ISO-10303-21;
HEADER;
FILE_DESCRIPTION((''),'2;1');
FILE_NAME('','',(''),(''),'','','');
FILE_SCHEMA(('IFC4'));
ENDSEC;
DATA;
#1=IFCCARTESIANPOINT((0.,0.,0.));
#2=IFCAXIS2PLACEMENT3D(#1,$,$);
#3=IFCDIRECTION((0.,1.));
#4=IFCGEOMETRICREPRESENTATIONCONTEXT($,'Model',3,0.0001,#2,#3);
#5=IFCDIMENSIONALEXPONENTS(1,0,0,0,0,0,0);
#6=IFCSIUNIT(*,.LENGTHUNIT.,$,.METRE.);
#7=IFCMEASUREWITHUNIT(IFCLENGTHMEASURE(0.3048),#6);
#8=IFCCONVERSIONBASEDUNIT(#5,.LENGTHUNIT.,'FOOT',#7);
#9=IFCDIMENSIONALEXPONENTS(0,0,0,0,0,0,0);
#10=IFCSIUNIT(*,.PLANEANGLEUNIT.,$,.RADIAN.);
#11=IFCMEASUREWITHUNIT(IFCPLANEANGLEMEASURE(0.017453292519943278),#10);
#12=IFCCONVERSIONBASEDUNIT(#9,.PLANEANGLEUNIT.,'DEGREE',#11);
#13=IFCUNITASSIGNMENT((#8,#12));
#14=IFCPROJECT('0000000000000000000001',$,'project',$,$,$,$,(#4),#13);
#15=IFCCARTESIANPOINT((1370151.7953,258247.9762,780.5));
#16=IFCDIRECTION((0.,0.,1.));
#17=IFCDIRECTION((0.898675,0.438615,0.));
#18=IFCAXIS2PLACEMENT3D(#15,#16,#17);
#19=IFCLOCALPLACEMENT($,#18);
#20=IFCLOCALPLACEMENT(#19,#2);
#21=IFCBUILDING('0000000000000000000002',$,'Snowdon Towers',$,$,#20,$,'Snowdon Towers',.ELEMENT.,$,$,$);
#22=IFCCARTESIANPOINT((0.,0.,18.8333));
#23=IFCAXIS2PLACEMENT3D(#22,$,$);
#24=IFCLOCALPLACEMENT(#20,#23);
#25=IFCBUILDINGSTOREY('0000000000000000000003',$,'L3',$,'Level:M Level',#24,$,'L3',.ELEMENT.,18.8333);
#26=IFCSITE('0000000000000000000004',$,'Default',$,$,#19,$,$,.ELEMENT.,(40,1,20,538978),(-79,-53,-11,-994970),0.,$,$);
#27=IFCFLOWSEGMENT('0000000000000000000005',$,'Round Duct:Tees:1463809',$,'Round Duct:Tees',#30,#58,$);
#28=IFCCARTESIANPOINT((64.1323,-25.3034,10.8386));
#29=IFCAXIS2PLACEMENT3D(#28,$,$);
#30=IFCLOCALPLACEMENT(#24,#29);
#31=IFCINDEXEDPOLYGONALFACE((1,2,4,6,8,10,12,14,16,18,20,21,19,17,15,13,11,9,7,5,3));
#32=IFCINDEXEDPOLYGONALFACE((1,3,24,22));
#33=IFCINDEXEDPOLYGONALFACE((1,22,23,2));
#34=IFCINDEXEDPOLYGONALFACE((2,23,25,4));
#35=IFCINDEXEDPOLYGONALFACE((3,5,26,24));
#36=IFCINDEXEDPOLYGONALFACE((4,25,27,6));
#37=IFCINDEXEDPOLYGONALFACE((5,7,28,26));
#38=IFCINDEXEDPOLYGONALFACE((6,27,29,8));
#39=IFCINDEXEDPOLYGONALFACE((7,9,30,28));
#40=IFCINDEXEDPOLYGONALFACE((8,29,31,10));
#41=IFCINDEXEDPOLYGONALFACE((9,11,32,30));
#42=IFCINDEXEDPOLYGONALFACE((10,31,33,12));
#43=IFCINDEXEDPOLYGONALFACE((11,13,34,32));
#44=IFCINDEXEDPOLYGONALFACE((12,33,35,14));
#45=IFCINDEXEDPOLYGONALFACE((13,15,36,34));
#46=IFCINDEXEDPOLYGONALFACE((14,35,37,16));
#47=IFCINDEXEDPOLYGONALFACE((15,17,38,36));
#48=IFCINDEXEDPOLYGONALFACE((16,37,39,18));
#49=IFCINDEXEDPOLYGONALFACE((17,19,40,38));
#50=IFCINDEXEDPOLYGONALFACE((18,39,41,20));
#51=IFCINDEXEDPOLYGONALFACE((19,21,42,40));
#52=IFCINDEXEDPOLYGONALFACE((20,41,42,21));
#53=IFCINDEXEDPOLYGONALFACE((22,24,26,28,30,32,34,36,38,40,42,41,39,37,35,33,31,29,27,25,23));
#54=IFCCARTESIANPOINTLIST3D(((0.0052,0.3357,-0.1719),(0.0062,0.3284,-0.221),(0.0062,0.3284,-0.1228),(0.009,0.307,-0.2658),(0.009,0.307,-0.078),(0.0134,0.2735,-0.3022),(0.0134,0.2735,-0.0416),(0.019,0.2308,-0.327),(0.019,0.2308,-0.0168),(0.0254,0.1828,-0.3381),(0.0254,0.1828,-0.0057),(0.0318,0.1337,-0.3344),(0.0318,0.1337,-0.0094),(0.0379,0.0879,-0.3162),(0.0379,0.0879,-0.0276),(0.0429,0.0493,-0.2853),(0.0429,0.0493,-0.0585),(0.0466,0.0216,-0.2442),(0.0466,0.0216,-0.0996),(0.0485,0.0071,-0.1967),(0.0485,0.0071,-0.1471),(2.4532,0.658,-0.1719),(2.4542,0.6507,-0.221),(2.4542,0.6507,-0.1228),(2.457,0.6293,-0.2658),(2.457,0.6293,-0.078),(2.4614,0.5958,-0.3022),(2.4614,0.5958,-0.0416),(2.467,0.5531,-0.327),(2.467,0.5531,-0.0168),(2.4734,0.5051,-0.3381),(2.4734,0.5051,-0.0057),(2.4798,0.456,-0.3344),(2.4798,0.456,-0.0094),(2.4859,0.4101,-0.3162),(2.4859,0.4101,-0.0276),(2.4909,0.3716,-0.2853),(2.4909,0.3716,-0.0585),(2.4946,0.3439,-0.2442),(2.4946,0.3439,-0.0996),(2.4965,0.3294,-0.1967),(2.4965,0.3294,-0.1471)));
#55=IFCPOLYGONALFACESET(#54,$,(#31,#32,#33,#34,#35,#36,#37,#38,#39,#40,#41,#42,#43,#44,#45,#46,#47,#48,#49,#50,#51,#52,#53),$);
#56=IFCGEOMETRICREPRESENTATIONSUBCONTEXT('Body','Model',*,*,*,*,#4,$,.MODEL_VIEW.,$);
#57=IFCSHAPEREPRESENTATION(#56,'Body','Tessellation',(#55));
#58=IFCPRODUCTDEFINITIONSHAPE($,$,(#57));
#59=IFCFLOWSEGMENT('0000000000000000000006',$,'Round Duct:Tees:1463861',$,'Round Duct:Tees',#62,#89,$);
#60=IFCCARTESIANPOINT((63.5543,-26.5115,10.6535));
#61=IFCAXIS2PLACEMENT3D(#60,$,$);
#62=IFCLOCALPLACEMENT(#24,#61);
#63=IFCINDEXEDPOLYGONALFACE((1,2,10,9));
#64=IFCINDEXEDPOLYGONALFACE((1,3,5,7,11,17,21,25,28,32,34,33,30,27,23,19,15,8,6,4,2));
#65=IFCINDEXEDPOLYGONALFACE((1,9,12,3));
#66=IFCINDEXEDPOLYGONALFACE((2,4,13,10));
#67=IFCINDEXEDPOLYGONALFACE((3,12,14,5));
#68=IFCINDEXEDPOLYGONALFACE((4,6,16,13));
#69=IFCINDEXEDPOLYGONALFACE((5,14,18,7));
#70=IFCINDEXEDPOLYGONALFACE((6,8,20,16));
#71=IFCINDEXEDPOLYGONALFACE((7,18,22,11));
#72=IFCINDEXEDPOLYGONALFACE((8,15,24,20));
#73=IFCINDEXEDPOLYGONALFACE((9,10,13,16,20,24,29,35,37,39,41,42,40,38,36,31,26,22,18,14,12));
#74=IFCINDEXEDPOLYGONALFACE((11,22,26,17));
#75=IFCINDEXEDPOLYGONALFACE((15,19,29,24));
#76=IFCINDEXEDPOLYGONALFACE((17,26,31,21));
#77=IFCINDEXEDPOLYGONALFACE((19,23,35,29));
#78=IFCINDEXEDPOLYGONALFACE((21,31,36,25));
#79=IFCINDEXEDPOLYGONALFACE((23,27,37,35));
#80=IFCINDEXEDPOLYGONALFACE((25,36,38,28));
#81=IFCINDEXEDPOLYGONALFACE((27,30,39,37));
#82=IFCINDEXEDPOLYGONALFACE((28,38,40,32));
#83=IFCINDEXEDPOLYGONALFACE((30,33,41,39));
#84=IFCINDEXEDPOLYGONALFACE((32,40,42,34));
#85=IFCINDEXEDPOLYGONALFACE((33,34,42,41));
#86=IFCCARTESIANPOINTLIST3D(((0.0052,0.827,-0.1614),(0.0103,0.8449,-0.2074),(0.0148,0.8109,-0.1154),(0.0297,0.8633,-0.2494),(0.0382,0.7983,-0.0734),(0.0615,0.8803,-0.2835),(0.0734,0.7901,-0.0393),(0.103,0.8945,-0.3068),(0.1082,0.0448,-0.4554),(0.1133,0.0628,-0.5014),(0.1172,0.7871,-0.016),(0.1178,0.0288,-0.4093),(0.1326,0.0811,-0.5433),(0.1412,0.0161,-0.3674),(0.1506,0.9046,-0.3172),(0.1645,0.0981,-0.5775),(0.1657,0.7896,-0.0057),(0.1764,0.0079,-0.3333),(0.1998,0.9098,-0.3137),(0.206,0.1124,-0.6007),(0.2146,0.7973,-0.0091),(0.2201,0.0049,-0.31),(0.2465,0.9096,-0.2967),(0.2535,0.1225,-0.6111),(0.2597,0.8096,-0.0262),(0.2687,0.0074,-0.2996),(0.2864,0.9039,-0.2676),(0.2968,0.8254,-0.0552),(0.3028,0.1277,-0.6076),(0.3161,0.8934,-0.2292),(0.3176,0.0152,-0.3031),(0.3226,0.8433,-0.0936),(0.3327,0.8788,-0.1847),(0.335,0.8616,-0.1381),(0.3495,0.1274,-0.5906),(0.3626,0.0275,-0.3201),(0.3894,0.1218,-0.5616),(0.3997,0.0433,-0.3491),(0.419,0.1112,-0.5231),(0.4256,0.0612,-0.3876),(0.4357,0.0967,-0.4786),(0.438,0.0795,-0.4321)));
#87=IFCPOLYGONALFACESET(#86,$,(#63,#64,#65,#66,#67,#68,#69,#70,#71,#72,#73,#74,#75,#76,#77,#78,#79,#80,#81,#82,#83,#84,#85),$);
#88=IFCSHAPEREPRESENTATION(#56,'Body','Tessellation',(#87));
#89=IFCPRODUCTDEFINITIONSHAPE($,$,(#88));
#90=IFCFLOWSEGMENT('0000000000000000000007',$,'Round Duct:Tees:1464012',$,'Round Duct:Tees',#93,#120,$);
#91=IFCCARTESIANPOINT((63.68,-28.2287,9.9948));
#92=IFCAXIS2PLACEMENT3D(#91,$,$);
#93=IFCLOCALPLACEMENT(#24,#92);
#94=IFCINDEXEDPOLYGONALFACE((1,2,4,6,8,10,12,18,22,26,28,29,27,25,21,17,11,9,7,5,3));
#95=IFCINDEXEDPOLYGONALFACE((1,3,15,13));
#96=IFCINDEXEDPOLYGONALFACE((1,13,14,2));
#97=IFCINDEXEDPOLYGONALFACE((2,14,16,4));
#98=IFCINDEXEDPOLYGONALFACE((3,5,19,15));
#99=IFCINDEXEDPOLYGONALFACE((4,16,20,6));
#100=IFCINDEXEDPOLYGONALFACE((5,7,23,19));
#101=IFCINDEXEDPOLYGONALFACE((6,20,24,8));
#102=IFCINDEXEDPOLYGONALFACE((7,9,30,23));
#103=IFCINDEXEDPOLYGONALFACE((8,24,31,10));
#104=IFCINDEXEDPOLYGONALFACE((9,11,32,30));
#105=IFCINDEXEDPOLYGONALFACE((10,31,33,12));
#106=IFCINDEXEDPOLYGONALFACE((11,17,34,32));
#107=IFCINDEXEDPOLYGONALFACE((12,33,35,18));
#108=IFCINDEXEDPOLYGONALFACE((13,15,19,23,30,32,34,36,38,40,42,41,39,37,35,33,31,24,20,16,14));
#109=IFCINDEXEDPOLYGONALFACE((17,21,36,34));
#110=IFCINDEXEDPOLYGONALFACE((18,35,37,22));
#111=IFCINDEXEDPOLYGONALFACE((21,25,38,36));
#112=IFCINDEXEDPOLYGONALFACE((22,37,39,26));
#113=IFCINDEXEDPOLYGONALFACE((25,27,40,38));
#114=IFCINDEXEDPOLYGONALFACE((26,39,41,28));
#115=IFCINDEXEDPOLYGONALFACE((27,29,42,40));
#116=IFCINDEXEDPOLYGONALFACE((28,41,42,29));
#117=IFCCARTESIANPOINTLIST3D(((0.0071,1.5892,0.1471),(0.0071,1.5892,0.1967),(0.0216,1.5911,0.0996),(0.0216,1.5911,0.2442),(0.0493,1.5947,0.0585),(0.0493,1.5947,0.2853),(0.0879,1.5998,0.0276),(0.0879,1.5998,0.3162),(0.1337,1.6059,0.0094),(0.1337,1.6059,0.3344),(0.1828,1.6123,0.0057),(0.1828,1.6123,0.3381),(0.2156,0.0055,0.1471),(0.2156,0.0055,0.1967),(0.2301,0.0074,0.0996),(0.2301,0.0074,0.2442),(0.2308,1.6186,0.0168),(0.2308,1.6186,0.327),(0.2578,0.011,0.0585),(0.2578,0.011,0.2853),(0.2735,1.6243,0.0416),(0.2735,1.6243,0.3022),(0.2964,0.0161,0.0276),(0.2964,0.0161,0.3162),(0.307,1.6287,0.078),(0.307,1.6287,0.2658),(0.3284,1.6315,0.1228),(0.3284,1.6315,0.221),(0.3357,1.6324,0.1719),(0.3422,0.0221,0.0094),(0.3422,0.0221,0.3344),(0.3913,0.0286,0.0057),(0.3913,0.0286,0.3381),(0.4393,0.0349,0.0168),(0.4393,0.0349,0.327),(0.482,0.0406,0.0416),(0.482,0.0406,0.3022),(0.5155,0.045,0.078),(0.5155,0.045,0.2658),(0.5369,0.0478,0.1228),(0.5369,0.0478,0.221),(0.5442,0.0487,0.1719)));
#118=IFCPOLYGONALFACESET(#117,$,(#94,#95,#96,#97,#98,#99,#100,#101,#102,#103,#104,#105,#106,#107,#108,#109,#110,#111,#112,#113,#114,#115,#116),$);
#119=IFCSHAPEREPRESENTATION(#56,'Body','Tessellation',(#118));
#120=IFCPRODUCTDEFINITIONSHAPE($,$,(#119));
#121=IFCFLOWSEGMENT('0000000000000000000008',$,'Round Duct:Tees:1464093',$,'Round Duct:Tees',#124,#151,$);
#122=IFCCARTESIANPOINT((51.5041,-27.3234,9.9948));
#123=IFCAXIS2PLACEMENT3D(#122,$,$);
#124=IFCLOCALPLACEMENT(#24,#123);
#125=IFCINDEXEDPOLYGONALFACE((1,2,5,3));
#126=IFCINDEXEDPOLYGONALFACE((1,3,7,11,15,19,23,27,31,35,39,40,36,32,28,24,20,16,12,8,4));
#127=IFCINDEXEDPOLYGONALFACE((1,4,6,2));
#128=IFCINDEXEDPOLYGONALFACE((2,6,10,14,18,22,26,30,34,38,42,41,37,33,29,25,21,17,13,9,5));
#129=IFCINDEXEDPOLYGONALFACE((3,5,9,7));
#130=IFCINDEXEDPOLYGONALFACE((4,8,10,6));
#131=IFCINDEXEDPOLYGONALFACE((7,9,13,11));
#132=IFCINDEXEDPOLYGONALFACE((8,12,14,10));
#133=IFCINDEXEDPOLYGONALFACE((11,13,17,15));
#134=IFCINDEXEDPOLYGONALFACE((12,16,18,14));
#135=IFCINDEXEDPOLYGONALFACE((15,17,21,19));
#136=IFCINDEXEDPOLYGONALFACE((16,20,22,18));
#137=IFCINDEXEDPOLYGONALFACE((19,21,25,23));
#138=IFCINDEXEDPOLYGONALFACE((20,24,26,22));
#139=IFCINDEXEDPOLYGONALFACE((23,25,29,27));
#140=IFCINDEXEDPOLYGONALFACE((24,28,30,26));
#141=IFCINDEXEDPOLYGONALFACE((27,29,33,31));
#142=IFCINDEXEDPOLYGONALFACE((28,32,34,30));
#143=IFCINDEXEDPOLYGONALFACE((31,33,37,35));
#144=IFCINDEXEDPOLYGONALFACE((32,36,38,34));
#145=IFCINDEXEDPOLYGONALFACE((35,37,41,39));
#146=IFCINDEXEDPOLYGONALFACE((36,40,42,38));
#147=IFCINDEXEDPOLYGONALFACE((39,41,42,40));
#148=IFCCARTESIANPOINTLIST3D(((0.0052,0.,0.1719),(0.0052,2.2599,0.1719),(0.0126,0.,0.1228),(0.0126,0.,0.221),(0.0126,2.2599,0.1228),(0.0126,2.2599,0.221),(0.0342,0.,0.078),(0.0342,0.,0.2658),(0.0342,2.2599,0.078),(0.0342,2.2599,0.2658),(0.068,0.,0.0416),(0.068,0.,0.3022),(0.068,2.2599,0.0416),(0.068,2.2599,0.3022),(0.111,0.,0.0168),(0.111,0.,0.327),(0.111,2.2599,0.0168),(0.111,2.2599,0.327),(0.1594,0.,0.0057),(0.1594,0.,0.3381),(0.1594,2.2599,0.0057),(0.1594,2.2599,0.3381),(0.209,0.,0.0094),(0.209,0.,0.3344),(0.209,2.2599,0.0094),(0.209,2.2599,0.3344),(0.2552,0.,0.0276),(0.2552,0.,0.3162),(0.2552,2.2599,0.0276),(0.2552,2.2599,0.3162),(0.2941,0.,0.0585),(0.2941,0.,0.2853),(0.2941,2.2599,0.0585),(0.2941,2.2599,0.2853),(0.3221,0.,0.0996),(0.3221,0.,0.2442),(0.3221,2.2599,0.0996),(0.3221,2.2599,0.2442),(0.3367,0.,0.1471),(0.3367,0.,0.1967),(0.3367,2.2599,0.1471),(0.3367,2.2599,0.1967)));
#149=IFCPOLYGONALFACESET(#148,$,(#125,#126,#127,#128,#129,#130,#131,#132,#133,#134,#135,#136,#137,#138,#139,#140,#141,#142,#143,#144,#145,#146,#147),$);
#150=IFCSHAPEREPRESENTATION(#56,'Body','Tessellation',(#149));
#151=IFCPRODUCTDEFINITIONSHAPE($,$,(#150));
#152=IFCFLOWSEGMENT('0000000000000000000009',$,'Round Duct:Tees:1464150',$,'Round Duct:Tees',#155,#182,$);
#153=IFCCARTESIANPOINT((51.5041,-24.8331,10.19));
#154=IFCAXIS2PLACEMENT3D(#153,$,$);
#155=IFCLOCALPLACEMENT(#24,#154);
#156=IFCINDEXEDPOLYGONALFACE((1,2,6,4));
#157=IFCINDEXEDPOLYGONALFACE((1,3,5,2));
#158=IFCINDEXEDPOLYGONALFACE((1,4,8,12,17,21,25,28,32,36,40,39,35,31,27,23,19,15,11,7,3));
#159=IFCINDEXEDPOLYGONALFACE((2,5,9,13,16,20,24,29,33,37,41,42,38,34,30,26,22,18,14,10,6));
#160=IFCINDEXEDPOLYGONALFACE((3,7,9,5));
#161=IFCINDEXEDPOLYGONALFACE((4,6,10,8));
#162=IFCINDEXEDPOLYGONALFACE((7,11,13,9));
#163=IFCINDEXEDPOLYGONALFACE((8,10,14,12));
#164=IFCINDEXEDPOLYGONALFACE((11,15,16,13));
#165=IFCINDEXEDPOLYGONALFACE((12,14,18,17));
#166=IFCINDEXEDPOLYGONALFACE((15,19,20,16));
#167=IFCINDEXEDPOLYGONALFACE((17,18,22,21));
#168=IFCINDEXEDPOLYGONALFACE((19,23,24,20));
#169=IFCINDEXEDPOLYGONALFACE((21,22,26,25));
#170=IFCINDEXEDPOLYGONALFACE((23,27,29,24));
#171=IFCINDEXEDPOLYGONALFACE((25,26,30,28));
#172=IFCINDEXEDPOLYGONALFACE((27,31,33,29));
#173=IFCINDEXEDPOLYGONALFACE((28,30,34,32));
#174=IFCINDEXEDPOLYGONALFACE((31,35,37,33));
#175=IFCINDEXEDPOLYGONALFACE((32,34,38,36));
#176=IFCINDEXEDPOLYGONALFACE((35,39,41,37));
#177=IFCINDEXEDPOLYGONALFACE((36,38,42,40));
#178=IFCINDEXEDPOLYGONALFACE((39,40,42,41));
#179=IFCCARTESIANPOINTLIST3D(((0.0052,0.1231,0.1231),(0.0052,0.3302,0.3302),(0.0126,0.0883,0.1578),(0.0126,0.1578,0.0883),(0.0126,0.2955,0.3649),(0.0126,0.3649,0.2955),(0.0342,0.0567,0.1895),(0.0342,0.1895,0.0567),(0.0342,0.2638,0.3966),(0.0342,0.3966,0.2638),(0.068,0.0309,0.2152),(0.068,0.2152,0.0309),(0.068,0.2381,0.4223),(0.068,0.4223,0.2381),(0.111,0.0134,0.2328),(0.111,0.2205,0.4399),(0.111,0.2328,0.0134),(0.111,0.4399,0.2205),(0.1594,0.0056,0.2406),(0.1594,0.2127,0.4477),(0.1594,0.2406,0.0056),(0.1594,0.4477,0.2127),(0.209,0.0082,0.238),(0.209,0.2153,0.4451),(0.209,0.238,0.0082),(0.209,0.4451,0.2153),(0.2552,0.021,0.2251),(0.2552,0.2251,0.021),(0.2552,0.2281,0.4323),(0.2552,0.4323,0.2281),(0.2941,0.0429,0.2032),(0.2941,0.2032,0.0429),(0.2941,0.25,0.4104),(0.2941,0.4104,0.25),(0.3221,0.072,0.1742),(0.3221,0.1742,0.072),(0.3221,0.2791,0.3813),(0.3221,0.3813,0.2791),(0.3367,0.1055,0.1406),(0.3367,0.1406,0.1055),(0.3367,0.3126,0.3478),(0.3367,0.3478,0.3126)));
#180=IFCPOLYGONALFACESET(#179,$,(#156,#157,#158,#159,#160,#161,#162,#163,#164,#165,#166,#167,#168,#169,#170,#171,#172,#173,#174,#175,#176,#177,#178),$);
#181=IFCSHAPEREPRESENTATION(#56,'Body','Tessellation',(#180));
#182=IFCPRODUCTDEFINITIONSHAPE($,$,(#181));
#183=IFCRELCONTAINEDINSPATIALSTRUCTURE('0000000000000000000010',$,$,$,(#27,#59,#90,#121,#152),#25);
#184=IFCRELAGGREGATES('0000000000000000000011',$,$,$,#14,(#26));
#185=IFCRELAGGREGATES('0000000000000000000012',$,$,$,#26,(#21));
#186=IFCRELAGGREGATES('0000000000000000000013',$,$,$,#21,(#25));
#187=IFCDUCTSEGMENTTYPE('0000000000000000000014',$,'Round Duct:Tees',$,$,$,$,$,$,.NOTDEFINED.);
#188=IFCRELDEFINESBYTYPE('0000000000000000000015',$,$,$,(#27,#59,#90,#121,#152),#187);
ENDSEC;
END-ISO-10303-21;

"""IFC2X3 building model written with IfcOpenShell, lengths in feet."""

from ifc_helpers import new_model, entity, si_unit, converted_unit, direction, frame, frame_2d, origin, origin_2d_with_axis, place, context, subcontext, project, spatial, circle, extrude, type_object, element, save


model = new_model("IFC2X3")

# Units and contexts
model_context = context("Model", 3, precision=0.0001, world=origin(), true_north=direction((0.0, 1.0)))
body_context = subcontext(model_context, "Body", "Model", "MODEL_VIEW")
ifc_project = project(units=[converted_unit("LENGTHUNIT", "FOOT", entity("IfcLengthMeasure", 0.3048), si_unit("LENGTHUNIT", "METRE"), dimensions=[1, 0, 0, 0, 0, 0, 0]), converted_unit("PLANEANGLEUNIT", "DEGREE", entity("IfcPlaneAngleMeasure", 0.017453292519943278), si_unit("PLANEANGLEUNIT", "RADIAN"), dimensions=[0, 0, 0, 0, 0, 0, 0])], contexts=[model_context])

# Site, building, storey
site_placement = place(None, frame((1370151.7953, 258247.9762, 780.5), z_axis=(0.0, 0.0, 1.0), x_axis=(0.898675, 0.438615, 0.0)))
site = spatial("IfcSite", under=ifc_project, at=site_placement, Name="Default", CompositionType="ELEMENT", RefLatitude=(40, 1, 20, 538978), RefLongitude=(-79, -53, -11, -994970), RefElevation=0.0)
building_placement = place(site_placement, origin())
building = spatial("IfcBuilding", under=site, at=building_placement, Name="Snowdon Towers", LongName="Snowdon Towers", CompositionType="ELEMENT")
storey_placement = place(building_placement, frame((0.0, 0.0, 18.8333)))
storey = spatial("IfcBuildingStorey", under=building, at=storey_placement, Name="L3", ObjectType="Level:M Level", LongName="L3", CompositionType="ELEMENT", Elevation=18.8333)

# Flow segments
duct_segment_type = type_object("IfcDuctSegmentType", Name="Round Duct:Tees", PredefinedType="NOTDEFINED")
flow_segment_1_placement = place(storey_placement, frame((64.1323, -25.3034, 10.8386)))
element("IfcFlowSegment", 1, at=flow_segment_1_placement, inside=storey, type_object=duct_segment_type, Name="Round Duct:Tees:1463809", ObjectType="Round Duct:Tees", context=body_context, shape_type="SweptSolid", body=[
    extrude(circle(Radius=0.1667, at=frame_2d((0.0, 0.0), x_axis=(1.0, 0.0))), frame((0.027, 0.1705, -0.1719), z_axis=(0.991445, 0.130526, 0.0), x_axis=(-0.130526, 0.991445, 0.0)), (0.0, 0.0, 1.0), 2.4691),
])
flow_segment_2_placement = place(storey_placement, frame((63.5543, -26.5115, 10.6535)))
element("IfcFlowSegment", 2, at=flow_segment_2_placement, inside=storey, type_object=duct_segment_type, Name="Round Duct:Tees:1463861", ObjectType="Round Duct:Tees", context=body_context, shape_type="SweptSolid", body=[
    extrude(circle(Radius=0.1667, at=frame_2d((0.0, 0.0), x_axis=(1.0, 0.0))), frame((0.1705, 0.8487, -0.1614), z_axis=(0.122311, -0.929045, -0.349163), x_axis=(-0.991445, -0.130526, 0.0)), (0.0, 0.0, 1.0), 0.8419),
])
flow_segment_3_placement = place(storey_placement, frame((63.68, -28.2287, 9.9948)))
element("IfcFlowSegment", 3, at=flow_segment_3_placement, inside=storey, type_object=duct_segment_type, Name="Round Duct:Tees:1464012", ObjectType="Round Duct:Tees", context=body_context, shape_type="SweptSolid", body=[
    extrude(circle(Radius=0.1667, at=origin_2d_with_axis()), frame((0.379, 0.027, 0.1719), z_axis=(-0.130526, 0.991445, 0.0), x_axis=(0.991445, 0.130526, 0.0)), (0.0, 0.0, 1.0), 1.5974),
])
flow_segment_4_placement = place(storey_placement, frame((51.5041, -27.3234, 9.9948)))
element("IfcFlowSegment", 4, at=flow_segment_4_placement, inside=storey, type_object=duct_segment_type, Name="Round Duct:Tees:1464093", ObjectType="Round Duct:Tees", context=body_context, shape_type="SweptSolid", body=[
    extrude(circle(Radius=0.1667, at=frame_2d((0.0, 0.0), x_axis=(1.0, 0.0))), frame((0.1719, 0.0, 0.1719), z_axis=(0.0, 1.0, 0.0), x_axis=(-1.0, 0.0, 0.0)), (0.0, 0.0, 1.0), 2.2599),
])
flow_segment_5_placement = place(storey_placement, frame((51.5041, -24.8331, 10.19)))
element("IfcFlowSegment", 5, at=flow_segment_5_placement, inside=storey, type_object=duct_segment_type, Name="Round Duct:Tees:1464150", ObjectType="Round Duct:Tees", context=body_context, shape_type="SweptSolid", body=[
    extrude(circle(Radius=0.1667, at=frame_2d((0.0, 0.0), x_axis=(1.0, 0.0))), frame((0.1719, 0.1231, 0.1231), z_axis=(0.0, 0.707107, 0.707107), x_axis=(-1.0, 0.0, 0.0)), (0.0, 0.0, 1.0), 0.2929),
])

save(model, "model.ifc")
